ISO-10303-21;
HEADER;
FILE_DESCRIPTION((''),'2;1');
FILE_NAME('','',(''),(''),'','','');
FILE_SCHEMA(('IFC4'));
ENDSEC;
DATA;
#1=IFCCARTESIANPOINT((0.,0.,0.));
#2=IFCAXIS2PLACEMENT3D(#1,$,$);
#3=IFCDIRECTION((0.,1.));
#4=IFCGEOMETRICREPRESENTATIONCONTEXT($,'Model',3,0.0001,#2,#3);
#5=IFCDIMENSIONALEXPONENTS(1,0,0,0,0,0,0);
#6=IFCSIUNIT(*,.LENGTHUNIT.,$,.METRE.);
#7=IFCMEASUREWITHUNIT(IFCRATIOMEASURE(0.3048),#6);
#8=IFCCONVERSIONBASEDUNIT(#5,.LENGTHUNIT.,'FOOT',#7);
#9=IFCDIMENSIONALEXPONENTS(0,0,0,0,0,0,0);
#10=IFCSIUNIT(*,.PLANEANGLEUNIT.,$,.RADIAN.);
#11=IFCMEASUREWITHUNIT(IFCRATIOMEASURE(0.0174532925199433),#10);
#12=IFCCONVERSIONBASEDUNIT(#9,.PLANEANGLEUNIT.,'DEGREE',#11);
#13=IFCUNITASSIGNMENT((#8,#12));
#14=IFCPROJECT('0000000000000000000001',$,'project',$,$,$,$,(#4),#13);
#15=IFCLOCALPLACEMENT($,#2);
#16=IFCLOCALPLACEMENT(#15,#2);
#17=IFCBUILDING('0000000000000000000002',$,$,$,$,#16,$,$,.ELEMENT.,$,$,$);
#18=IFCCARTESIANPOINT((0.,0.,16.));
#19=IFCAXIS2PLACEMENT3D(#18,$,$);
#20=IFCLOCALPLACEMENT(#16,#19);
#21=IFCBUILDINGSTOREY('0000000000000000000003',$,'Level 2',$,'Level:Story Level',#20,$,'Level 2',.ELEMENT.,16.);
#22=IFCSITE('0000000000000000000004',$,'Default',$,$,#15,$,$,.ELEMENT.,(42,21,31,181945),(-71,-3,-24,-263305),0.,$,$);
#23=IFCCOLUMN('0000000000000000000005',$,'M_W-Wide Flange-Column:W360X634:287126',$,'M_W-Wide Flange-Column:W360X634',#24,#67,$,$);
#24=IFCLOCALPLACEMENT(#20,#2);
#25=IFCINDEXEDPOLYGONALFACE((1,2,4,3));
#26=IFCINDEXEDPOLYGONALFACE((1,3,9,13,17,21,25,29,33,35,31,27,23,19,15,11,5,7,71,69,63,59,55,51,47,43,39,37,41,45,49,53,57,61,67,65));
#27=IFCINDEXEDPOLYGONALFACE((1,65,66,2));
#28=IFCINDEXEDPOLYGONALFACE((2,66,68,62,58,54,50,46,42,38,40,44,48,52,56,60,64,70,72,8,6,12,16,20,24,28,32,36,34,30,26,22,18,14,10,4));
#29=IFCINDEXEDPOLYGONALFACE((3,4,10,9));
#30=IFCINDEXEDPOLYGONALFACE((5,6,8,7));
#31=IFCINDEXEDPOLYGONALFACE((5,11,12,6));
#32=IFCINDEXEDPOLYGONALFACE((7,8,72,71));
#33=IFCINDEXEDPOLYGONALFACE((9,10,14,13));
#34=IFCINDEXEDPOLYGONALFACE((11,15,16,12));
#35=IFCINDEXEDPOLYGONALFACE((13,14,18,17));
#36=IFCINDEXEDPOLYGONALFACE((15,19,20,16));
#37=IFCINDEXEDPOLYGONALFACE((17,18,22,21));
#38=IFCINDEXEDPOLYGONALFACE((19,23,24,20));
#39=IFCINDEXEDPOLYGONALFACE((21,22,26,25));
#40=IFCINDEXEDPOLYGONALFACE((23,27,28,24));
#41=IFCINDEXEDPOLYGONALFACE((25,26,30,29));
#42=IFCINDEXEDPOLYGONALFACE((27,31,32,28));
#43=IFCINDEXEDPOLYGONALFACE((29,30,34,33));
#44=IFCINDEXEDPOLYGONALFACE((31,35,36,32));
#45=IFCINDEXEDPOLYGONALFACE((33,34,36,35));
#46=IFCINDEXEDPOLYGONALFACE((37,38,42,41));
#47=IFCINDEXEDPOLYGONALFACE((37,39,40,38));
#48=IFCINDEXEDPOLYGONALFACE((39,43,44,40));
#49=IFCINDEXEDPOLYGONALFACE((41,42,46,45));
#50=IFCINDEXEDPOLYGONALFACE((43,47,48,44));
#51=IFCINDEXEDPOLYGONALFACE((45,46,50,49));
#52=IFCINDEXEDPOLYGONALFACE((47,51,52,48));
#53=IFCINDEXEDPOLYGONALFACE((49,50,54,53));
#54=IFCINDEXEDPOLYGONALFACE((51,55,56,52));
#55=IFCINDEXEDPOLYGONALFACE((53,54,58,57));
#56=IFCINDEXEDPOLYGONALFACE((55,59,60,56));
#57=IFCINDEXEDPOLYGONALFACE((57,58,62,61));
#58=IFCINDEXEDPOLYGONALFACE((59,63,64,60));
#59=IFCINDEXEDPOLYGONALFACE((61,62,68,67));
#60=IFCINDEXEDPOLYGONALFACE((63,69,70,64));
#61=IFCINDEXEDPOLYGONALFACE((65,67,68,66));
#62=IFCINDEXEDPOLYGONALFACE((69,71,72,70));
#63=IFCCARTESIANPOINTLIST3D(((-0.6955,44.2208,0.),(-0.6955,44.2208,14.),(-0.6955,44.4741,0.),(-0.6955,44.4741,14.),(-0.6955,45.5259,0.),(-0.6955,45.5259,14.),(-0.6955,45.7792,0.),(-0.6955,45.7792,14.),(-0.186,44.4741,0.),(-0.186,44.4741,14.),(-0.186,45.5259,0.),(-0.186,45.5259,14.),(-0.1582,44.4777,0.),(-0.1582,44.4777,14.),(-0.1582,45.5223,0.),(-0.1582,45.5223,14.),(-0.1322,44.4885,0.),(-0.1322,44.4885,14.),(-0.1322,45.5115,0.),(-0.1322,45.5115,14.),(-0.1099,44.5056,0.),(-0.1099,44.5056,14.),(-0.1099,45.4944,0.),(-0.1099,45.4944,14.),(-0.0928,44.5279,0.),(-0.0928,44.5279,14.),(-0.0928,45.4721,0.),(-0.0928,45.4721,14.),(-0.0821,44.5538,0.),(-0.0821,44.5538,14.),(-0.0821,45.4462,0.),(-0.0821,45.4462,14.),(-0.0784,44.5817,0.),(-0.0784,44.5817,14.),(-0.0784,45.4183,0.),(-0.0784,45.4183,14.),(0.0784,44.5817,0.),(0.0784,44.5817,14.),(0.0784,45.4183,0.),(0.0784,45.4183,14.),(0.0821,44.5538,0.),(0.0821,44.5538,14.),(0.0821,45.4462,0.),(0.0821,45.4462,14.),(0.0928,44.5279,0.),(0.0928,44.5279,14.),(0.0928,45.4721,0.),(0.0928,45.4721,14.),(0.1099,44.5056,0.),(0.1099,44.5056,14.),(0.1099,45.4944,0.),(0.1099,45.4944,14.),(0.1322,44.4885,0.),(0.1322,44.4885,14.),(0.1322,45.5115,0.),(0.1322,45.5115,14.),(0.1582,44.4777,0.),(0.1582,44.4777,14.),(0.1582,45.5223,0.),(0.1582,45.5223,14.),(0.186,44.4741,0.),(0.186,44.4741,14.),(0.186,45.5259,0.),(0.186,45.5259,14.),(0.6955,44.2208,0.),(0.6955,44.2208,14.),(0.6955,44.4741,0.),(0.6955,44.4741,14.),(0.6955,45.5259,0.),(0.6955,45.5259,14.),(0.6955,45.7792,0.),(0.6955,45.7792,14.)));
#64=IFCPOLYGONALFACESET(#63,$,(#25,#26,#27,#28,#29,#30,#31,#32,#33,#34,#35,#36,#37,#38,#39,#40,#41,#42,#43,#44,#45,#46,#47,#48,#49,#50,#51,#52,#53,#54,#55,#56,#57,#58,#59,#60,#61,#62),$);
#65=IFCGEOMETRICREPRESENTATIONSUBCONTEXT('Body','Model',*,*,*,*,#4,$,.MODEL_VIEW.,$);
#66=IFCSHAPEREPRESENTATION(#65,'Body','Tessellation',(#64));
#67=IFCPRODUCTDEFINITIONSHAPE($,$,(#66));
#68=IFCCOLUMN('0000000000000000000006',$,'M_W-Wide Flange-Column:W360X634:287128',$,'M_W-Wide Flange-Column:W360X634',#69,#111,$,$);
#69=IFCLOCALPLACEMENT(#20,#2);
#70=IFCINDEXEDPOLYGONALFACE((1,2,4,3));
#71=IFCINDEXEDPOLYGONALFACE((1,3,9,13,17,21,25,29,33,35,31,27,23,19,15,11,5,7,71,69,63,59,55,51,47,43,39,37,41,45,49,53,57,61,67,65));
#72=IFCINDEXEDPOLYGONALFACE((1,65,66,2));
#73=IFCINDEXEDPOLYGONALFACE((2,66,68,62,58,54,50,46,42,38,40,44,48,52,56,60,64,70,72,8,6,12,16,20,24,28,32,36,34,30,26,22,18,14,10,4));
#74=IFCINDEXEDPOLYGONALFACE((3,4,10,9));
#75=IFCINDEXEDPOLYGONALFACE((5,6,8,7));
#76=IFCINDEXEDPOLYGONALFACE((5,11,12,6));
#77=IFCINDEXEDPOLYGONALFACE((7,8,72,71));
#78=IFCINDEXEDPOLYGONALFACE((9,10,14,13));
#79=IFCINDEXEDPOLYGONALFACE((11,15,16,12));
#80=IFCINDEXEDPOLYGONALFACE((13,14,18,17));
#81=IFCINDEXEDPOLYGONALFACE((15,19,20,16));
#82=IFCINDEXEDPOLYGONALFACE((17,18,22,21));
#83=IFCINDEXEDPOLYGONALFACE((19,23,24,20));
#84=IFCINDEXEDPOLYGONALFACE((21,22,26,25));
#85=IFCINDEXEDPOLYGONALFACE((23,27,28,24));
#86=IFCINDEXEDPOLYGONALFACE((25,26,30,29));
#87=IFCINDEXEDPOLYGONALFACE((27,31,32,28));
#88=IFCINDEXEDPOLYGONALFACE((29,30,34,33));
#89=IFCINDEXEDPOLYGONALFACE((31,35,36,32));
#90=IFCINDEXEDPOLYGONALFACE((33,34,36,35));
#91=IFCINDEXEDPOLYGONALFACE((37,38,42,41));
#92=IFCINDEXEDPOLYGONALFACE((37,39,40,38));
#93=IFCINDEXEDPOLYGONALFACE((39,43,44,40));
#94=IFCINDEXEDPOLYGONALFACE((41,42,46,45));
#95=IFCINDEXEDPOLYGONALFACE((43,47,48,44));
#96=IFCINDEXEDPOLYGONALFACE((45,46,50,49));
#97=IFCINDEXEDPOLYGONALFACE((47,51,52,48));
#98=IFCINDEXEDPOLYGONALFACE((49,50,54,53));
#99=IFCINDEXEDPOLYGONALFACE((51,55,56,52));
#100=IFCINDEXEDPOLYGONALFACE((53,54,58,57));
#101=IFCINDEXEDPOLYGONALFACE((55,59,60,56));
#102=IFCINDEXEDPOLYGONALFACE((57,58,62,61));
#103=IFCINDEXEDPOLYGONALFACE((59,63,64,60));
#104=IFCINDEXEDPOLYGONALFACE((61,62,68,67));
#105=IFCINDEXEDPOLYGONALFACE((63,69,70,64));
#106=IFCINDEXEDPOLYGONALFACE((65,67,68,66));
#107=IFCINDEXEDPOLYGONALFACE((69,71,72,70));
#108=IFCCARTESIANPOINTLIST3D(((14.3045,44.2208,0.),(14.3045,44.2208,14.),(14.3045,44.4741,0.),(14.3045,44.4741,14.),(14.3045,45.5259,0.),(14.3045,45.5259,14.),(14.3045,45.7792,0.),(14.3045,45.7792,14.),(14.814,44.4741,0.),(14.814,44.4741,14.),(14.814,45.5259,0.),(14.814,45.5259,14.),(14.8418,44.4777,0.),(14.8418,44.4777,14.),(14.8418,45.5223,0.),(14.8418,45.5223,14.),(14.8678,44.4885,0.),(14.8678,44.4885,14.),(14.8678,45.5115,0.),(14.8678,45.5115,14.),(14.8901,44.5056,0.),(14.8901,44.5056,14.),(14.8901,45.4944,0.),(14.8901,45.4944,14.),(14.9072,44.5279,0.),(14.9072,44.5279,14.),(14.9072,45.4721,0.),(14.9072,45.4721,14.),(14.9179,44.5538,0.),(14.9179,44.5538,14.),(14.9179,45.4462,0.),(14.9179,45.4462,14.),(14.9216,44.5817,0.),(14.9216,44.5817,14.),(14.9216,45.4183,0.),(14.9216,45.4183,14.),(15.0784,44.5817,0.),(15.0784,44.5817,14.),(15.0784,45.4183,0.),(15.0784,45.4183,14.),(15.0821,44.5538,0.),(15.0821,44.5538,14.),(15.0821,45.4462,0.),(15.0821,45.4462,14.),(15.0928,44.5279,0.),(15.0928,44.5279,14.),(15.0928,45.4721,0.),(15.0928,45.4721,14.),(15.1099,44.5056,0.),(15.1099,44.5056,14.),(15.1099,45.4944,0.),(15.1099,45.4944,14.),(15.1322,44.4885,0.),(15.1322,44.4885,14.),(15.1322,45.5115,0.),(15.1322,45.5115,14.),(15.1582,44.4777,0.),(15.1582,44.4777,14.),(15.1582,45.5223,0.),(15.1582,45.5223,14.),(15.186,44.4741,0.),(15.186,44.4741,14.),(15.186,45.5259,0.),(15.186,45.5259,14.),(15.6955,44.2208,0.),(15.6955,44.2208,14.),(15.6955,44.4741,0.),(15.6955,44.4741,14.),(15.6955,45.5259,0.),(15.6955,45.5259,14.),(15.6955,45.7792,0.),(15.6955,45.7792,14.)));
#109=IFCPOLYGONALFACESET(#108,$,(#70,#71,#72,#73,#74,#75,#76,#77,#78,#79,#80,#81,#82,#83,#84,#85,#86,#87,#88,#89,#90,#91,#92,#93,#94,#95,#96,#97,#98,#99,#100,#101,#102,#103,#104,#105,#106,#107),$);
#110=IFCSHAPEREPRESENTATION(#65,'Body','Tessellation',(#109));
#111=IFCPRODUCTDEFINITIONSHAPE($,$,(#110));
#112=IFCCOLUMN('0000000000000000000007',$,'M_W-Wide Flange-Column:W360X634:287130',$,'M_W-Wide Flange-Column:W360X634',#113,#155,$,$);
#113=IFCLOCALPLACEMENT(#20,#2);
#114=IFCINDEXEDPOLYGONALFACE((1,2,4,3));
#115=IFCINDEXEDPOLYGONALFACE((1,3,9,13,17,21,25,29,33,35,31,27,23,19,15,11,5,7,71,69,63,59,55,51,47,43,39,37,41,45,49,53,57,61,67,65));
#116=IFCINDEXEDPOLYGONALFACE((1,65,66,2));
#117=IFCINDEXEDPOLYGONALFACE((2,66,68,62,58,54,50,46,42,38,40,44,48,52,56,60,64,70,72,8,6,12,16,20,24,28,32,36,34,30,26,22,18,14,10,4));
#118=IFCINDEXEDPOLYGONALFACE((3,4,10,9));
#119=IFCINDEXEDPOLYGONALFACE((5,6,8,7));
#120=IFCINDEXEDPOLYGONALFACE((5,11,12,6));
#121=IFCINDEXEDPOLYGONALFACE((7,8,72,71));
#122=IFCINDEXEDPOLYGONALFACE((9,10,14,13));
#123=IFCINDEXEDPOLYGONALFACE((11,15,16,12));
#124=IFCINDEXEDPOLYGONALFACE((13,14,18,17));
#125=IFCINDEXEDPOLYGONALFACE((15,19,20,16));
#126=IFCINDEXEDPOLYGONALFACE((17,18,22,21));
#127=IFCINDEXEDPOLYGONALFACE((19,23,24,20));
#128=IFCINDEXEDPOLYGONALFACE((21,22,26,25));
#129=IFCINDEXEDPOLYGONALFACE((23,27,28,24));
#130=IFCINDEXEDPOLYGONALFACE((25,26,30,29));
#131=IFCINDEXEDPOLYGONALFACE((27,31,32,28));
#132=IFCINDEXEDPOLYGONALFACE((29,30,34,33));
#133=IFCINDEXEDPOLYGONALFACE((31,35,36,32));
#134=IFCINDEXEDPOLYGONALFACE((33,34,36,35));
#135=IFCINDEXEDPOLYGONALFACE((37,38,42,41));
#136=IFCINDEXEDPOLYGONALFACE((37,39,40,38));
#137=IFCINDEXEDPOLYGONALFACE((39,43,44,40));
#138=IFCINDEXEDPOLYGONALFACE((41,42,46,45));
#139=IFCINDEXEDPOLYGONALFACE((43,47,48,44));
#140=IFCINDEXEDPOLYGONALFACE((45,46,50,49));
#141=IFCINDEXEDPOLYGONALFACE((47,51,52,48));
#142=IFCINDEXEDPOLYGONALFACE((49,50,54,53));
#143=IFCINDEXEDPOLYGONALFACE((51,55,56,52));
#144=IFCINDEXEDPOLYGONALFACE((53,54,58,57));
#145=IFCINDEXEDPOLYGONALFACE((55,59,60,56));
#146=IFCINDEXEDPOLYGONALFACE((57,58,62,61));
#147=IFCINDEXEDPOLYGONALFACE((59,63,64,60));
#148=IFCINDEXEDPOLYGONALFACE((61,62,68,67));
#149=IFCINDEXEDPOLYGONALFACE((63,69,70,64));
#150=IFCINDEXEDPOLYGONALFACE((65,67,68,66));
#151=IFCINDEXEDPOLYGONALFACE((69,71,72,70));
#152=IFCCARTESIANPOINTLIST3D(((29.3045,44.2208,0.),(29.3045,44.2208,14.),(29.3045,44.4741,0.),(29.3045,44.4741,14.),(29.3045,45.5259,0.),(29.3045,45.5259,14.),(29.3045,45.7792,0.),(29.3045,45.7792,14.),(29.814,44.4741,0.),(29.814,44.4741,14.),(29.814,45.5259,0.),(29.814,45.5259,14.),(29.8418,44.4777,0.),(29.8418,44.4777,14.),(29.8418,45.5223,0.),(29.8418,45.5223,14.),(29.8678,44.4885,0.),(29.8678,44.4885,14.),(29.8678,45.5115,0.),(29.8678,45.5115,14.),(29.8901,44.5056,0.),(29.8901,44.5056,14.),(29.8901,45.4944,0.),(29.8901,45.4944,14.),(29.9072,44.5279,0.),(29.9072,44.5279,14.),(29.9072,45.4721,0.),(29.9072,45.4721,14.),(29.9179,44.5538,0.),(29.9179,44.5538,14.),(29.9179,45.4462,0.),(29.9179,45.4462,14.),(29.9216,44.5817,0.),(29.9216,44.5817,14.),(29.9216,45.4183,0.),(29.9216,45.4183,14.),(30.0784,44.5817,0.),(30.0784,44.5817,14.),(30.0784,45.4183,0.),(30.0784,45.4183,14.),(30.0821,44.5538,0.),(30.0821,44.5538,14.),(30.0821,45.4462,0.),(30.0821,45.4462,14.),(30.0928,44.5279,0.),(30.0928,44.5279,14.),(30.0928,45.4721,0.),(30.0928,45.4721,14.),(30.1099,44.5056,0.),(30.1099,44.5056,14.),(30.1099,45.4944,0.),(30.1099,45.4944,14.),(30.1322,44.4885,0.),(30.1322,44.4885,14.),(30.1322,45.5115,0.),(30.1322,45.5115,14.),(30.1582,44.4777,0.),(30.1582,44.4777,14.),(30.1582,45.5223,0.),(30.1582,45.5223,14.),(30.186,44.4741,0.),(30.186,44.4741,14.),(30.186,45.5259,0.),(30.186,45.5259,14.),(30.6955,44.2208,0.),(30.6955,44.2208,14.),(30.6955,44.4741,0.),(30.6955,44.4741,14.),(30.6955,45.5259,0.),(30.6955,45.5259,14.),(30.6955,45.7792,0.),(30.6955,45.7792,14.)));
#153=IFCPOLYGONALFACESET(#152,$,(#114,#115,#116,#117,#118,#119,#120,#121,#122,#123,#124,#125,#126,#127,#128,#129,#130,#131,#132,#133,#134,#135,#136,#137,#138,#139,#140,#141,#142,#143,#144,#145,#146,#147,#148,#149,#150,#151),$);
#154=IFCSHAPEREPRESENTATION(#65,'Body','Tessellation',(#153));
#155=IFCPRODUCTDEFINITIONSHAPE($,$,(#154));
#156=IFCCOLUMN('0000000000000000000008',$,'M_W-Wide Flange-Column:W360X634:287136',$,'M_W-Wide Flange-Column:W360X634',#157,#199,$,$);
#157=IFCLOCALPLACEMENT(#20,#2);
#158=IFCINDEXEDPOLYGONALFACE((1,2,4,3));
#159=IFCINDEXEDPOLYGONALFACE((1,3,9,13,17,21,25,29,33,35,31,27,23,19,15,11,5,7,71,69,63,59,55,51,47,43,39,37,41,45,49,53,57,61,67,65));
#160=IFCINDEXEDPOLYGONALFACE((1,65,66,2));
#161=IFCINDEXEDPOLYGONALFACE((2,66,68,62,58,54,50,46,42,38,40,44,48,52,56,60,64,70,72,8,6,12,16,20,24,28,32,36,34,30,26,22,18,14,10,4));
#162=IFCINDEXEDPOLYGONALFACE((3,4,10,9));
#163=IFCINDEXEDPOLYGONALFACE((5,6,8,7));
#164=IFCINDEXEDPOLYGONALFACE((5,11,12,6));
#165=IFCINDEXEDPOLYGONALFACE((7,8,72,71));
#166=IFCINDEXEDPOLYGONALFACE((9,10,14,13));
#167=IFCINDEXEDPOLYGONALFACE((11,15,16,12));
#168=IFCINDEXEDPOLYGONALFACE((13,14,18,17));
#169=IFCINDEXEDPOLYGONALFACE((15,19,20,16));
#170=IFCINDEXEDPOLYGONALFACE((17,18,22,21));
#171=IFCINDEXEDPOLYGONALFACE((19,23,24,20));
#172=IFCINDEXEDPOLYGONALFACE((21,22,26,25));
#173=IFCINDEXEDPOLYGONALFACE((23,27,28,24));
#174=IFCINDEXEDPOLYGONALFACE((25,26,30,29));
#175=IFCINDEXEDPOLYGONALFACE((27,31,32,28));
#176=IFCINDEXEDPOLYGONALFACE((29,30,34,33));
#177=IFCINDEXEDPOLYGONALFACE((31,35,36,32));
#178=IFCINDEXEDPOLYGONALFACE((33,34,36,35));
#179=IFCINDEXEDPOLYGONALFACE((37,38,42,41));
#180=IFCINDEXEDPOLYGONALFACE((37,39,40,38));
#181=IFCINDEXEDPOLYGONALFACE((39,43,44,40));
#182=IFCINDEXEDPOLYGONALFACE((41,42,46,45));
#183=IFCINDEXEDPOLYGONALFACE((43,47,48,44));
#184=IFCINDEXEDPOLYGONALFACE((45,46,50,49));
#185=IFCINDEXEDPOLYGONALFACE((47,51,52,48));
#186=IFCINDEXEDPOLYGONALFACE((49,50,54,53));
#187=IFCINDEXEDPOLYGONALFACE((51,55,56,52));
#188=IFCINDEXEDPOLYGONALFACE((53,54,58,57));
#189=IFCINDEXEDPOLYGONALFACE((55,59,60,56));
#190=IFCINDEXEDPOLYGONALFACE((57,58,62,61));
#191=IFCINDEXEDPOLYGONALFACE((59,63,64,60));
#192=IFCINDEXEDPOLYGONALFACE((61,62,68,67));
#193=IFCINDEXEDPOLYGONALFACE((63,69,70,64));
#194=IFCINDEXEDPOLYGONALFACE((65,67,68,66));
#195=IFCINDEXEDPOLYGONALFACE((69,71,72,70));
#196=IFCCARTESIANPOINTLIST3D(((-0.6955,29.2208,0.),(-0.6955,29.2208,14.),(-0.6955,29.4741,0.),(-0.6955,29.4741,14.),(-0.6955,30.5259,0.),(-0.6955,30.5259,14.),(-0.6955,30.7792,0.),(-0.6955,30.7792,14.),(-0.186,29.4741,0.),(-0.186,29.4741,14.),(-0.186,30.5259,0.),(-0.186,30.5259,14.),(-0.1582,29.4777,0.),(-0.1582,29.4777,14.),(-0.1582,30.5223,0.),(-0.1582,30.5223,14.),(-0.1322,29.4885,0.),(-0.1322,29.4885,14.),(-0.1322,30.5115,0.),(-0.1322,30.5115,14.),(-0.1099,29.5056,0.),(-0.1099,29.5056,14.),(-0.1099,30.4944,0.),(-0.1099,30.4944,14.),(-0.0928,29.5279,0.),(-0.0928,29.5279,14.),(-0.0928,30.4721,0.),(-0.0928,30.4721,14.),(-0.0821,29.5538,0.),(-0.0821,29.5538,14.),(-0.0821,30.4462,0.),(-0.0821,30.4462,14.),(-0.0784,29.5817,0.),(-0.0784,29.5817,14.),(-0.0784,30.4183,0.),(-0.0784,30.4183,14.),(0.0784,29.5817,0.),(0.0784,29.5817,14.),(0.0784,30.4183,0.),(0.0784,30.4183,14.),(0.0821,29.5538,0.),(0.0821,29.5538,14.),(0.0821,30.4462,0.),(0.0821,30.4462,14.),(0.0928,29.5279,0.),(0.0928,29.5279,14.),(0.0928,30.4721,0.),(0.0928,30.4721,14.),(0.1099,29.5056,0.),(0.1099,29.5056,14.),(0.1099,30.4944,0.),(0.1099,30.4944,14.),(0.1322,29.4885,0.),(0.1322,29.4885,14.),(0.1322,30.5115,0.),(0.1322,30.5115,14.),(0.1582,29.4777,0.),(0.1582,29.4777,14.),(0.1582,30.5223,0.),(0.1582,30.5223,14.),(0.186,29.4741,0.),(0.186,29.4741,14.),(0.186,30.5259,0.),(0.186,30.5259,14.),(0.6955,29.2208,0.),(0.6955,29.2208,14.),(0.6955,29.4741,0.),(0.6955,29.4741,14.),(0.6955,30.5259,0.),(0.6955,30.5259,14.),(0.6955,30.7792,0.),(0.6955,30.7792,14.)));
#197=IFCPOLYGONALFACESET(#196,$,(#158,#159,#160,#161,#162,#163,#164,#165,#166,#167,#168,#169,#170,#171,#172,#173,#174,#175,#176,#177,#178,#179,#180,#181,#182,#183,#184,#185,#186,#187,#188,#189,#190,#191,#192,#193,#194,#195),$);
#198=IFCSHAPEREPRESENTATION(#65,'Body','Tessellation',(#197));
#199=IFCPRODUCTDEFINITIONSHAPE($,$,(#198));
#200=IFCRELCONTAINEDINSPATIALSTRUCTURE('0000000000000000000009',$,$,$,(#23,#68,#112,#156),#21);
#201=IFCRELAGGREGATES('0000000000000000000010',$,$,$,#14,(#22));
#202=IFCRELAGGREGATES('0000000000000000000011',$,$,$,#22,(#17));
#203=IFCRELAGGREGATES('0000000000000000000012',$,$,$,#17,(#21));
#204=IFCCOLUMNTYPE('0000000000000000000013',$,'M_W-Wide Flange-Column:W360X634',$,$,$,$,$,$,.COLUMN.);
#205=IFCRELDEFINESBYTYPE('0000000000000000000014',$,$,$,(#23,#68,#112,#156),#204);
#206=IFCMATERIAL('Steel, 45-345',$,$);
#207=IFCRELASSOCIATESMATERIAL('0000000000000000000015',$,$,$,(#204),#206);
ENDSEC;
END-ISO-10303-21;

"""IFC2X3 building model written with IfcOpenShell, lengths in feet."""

from ifc_helpers import new_model, entity, si_unit, converted_unit, direction, frame, frame_2d, origin, place, context, subcontext, project, spatial, polyline, circle_curve, parameter, trimmed, segment, composite_curve, outline, extrude, source, transform, mapped, material, type_object, type_shapes, element, save


model = new_model("IFC2X3")

# Units and contexts
model_context = context("Model", 3, precision=0.0001, world=origin(), true_north=direction((0.0, 1.0)))
body_context = subcontext(model_context, "Body", "Model", "MODEL_VIEW")
ifc_project = project(units=[converted_unit("LENGTHUNIT", "FOOT", entity("IfcRatioMeasure", 0.3048), si_unit("LENGTHUNIT", "METRE"), dimensions=[1, 0, 0, 0, 0, 0, 0]), converted_unit("PLANEANGLEUNIT", "DEGREE", entity("IfcRatioMeasure", 0.0174532925199433), si_unit("PLANEANGLEUNIT", "RADIAN"), dimensions=[0, 0, 0, 0, 0, 0, 0])], contexts=[model_context])

# Site, building, storey
site_placement = place(None, origin())
site = spatial("IfcSite", under=ifc_project, at=site_placement, Name="Default", CompositionType="ELEMENT", RefLatitude=(42, 21, 31, 181945), RefLongitude=(-71, -3, -24, -263305), RefElevation=0.0)
building_placement = place(site_placement, origin())
building = spatial("IfcBuilding", under=site, at=building_placement, CompositionType="ELEMENT")
storey_placement = place(building_placement, frame((0.0, 0.0, 16.0)))
storey = spatial("IfcBuildingStorey", under=building, at=storey_placement, Name="Level 2", ObjectType="Level:Story Level", LongName="Level 2", CompositionType="ELEMENT", Elevation=16.0)

# Columns
ifc_material = material(Name="Steel, 45-345")
column_type = type_object("IfcColumnType", Name="M_W-Wide Flange-Column:W360X634", PredefinedType="COLUMN", material=ifc_material)
shared_shape = source(origin(), body_context, "Body", "SweptSolid", [
    extrude(outline(composite_curve([segment(polyline([(0.5259, -0.6955), (0.7792, -0.6955)]), True, "CONTINUOUS"), segment(polyline([(0.7792, -0.6955), (0.7792, 0.6955)]), True, "CONTINUOUS"), segment(polyline([(0.7792, 0.6955), (0.5259, 0.6955)]), True, "CONTINUOUS"), segment(polyline([(0.5259, 0.6955), (0.5259, 0.186)]), True, "CONTINUOUS"), segment(trimmed(circle_curve(frame_2d((0.4183, 0.186), x_axis=(1.0, 0.0)), 0.1076), [parameter(270.0)], [parameter(0.0)], True, "PARAMETER"), False, "CONTINUOUS"), segment(polyline([(0.4183, 0.0784), (-0.4183, 0.0784)]), True, "CONTINUOUS"), segment(trimmed(circle_curve(frame_2d((-0.4183, 0.186), x_axis=(0.0, -1.0)), 0.1076), [parameter(270.0)], [parameter(0.0)], True, "PARAMETER"), False, "CONTINUOUS"), segment(polyline([(-0.5259, 0.186), (-0.5259, 0.6955)]), True, "CONTINUOUS"), segment(polyline([(-0.5259, 0.6955), (-0.7792, 0.6955)]), True, "CONTINUOUS"), segment(polyline([(-0.7792, 0.6955), (-0.7792, -0.6955)]), True, "CONTINUOUS"), segment(polyline([(-0.7792, -0.6955), (-0.5259, -0.6955)]), True, "CONTINUOUS"), segment(polyline([(-0.5259, -0.6955), (-0.5259, -0.186)]), True, "CONTINUOUS"), segment(trimmed(circle_curve(frame_2d((-0.4183, -0.186), x_axis=(-1.0, 0.0)), 0.1076), [parameter(270.0)], [parameter(0.0)], True, "PARAMETER"), False, "CONTINUOUS"), segment(polyline([(-0.4183, -0.0784), (0.4183, -0.0784)]), True, "CONTINUOUS"), segment(trimmed(circle_curve(frame_2d((0.4183, -0.186), x_axis=(0.0, 1.0)), 0.1076), [parameter(270.0)], [parameter(0.0)], True, "PARAMETER"), False, "CONTINUOUS"), segment(polyline([(0.5259, -0.186), (0.5259, -0.6955)]), True, "CONTINUOUS")], self_intersect=False)), frame((0.0, 0.0, 16.0), z_axis=(0.0, 0.0, 1.0), x_axis=(0.0, -1.0, 0.0)), (0.0, 0.0, 1.0), 14.0),
])
type_shapes(column_type, [shared_shape])
for number, where, name in (
    (1, (0.0, 45.0, -16.0), "M_W-Wide Flange-Column:W360X634:287126"),
    (2, (15.0, 45.0, -16.0), "M_W-Wide Flange-Column:W360X634:287128"),
    (3, (30.0, 45.0, -16.0), "M_W-Wide Flange-Column:W360X634:287130"),
    (4, (0.0, 30.0, -16.0), "M_W-Wide Flange-Column:W360X634:287136"),
):
    element("IfcColumn", number, at=place(storey_placement, frame(where)), inside=storey, type_object=column_type, Name=name, ObjectType="M_W-Wide Flange-Column:W360X634", context=body_context, shape_type="MappedRepresentation", body=[
        mapped(shared_shape, transform((0.0, 0.0, 0.0), scale=1.0)),
    ])

save(model, "model.ifc")
